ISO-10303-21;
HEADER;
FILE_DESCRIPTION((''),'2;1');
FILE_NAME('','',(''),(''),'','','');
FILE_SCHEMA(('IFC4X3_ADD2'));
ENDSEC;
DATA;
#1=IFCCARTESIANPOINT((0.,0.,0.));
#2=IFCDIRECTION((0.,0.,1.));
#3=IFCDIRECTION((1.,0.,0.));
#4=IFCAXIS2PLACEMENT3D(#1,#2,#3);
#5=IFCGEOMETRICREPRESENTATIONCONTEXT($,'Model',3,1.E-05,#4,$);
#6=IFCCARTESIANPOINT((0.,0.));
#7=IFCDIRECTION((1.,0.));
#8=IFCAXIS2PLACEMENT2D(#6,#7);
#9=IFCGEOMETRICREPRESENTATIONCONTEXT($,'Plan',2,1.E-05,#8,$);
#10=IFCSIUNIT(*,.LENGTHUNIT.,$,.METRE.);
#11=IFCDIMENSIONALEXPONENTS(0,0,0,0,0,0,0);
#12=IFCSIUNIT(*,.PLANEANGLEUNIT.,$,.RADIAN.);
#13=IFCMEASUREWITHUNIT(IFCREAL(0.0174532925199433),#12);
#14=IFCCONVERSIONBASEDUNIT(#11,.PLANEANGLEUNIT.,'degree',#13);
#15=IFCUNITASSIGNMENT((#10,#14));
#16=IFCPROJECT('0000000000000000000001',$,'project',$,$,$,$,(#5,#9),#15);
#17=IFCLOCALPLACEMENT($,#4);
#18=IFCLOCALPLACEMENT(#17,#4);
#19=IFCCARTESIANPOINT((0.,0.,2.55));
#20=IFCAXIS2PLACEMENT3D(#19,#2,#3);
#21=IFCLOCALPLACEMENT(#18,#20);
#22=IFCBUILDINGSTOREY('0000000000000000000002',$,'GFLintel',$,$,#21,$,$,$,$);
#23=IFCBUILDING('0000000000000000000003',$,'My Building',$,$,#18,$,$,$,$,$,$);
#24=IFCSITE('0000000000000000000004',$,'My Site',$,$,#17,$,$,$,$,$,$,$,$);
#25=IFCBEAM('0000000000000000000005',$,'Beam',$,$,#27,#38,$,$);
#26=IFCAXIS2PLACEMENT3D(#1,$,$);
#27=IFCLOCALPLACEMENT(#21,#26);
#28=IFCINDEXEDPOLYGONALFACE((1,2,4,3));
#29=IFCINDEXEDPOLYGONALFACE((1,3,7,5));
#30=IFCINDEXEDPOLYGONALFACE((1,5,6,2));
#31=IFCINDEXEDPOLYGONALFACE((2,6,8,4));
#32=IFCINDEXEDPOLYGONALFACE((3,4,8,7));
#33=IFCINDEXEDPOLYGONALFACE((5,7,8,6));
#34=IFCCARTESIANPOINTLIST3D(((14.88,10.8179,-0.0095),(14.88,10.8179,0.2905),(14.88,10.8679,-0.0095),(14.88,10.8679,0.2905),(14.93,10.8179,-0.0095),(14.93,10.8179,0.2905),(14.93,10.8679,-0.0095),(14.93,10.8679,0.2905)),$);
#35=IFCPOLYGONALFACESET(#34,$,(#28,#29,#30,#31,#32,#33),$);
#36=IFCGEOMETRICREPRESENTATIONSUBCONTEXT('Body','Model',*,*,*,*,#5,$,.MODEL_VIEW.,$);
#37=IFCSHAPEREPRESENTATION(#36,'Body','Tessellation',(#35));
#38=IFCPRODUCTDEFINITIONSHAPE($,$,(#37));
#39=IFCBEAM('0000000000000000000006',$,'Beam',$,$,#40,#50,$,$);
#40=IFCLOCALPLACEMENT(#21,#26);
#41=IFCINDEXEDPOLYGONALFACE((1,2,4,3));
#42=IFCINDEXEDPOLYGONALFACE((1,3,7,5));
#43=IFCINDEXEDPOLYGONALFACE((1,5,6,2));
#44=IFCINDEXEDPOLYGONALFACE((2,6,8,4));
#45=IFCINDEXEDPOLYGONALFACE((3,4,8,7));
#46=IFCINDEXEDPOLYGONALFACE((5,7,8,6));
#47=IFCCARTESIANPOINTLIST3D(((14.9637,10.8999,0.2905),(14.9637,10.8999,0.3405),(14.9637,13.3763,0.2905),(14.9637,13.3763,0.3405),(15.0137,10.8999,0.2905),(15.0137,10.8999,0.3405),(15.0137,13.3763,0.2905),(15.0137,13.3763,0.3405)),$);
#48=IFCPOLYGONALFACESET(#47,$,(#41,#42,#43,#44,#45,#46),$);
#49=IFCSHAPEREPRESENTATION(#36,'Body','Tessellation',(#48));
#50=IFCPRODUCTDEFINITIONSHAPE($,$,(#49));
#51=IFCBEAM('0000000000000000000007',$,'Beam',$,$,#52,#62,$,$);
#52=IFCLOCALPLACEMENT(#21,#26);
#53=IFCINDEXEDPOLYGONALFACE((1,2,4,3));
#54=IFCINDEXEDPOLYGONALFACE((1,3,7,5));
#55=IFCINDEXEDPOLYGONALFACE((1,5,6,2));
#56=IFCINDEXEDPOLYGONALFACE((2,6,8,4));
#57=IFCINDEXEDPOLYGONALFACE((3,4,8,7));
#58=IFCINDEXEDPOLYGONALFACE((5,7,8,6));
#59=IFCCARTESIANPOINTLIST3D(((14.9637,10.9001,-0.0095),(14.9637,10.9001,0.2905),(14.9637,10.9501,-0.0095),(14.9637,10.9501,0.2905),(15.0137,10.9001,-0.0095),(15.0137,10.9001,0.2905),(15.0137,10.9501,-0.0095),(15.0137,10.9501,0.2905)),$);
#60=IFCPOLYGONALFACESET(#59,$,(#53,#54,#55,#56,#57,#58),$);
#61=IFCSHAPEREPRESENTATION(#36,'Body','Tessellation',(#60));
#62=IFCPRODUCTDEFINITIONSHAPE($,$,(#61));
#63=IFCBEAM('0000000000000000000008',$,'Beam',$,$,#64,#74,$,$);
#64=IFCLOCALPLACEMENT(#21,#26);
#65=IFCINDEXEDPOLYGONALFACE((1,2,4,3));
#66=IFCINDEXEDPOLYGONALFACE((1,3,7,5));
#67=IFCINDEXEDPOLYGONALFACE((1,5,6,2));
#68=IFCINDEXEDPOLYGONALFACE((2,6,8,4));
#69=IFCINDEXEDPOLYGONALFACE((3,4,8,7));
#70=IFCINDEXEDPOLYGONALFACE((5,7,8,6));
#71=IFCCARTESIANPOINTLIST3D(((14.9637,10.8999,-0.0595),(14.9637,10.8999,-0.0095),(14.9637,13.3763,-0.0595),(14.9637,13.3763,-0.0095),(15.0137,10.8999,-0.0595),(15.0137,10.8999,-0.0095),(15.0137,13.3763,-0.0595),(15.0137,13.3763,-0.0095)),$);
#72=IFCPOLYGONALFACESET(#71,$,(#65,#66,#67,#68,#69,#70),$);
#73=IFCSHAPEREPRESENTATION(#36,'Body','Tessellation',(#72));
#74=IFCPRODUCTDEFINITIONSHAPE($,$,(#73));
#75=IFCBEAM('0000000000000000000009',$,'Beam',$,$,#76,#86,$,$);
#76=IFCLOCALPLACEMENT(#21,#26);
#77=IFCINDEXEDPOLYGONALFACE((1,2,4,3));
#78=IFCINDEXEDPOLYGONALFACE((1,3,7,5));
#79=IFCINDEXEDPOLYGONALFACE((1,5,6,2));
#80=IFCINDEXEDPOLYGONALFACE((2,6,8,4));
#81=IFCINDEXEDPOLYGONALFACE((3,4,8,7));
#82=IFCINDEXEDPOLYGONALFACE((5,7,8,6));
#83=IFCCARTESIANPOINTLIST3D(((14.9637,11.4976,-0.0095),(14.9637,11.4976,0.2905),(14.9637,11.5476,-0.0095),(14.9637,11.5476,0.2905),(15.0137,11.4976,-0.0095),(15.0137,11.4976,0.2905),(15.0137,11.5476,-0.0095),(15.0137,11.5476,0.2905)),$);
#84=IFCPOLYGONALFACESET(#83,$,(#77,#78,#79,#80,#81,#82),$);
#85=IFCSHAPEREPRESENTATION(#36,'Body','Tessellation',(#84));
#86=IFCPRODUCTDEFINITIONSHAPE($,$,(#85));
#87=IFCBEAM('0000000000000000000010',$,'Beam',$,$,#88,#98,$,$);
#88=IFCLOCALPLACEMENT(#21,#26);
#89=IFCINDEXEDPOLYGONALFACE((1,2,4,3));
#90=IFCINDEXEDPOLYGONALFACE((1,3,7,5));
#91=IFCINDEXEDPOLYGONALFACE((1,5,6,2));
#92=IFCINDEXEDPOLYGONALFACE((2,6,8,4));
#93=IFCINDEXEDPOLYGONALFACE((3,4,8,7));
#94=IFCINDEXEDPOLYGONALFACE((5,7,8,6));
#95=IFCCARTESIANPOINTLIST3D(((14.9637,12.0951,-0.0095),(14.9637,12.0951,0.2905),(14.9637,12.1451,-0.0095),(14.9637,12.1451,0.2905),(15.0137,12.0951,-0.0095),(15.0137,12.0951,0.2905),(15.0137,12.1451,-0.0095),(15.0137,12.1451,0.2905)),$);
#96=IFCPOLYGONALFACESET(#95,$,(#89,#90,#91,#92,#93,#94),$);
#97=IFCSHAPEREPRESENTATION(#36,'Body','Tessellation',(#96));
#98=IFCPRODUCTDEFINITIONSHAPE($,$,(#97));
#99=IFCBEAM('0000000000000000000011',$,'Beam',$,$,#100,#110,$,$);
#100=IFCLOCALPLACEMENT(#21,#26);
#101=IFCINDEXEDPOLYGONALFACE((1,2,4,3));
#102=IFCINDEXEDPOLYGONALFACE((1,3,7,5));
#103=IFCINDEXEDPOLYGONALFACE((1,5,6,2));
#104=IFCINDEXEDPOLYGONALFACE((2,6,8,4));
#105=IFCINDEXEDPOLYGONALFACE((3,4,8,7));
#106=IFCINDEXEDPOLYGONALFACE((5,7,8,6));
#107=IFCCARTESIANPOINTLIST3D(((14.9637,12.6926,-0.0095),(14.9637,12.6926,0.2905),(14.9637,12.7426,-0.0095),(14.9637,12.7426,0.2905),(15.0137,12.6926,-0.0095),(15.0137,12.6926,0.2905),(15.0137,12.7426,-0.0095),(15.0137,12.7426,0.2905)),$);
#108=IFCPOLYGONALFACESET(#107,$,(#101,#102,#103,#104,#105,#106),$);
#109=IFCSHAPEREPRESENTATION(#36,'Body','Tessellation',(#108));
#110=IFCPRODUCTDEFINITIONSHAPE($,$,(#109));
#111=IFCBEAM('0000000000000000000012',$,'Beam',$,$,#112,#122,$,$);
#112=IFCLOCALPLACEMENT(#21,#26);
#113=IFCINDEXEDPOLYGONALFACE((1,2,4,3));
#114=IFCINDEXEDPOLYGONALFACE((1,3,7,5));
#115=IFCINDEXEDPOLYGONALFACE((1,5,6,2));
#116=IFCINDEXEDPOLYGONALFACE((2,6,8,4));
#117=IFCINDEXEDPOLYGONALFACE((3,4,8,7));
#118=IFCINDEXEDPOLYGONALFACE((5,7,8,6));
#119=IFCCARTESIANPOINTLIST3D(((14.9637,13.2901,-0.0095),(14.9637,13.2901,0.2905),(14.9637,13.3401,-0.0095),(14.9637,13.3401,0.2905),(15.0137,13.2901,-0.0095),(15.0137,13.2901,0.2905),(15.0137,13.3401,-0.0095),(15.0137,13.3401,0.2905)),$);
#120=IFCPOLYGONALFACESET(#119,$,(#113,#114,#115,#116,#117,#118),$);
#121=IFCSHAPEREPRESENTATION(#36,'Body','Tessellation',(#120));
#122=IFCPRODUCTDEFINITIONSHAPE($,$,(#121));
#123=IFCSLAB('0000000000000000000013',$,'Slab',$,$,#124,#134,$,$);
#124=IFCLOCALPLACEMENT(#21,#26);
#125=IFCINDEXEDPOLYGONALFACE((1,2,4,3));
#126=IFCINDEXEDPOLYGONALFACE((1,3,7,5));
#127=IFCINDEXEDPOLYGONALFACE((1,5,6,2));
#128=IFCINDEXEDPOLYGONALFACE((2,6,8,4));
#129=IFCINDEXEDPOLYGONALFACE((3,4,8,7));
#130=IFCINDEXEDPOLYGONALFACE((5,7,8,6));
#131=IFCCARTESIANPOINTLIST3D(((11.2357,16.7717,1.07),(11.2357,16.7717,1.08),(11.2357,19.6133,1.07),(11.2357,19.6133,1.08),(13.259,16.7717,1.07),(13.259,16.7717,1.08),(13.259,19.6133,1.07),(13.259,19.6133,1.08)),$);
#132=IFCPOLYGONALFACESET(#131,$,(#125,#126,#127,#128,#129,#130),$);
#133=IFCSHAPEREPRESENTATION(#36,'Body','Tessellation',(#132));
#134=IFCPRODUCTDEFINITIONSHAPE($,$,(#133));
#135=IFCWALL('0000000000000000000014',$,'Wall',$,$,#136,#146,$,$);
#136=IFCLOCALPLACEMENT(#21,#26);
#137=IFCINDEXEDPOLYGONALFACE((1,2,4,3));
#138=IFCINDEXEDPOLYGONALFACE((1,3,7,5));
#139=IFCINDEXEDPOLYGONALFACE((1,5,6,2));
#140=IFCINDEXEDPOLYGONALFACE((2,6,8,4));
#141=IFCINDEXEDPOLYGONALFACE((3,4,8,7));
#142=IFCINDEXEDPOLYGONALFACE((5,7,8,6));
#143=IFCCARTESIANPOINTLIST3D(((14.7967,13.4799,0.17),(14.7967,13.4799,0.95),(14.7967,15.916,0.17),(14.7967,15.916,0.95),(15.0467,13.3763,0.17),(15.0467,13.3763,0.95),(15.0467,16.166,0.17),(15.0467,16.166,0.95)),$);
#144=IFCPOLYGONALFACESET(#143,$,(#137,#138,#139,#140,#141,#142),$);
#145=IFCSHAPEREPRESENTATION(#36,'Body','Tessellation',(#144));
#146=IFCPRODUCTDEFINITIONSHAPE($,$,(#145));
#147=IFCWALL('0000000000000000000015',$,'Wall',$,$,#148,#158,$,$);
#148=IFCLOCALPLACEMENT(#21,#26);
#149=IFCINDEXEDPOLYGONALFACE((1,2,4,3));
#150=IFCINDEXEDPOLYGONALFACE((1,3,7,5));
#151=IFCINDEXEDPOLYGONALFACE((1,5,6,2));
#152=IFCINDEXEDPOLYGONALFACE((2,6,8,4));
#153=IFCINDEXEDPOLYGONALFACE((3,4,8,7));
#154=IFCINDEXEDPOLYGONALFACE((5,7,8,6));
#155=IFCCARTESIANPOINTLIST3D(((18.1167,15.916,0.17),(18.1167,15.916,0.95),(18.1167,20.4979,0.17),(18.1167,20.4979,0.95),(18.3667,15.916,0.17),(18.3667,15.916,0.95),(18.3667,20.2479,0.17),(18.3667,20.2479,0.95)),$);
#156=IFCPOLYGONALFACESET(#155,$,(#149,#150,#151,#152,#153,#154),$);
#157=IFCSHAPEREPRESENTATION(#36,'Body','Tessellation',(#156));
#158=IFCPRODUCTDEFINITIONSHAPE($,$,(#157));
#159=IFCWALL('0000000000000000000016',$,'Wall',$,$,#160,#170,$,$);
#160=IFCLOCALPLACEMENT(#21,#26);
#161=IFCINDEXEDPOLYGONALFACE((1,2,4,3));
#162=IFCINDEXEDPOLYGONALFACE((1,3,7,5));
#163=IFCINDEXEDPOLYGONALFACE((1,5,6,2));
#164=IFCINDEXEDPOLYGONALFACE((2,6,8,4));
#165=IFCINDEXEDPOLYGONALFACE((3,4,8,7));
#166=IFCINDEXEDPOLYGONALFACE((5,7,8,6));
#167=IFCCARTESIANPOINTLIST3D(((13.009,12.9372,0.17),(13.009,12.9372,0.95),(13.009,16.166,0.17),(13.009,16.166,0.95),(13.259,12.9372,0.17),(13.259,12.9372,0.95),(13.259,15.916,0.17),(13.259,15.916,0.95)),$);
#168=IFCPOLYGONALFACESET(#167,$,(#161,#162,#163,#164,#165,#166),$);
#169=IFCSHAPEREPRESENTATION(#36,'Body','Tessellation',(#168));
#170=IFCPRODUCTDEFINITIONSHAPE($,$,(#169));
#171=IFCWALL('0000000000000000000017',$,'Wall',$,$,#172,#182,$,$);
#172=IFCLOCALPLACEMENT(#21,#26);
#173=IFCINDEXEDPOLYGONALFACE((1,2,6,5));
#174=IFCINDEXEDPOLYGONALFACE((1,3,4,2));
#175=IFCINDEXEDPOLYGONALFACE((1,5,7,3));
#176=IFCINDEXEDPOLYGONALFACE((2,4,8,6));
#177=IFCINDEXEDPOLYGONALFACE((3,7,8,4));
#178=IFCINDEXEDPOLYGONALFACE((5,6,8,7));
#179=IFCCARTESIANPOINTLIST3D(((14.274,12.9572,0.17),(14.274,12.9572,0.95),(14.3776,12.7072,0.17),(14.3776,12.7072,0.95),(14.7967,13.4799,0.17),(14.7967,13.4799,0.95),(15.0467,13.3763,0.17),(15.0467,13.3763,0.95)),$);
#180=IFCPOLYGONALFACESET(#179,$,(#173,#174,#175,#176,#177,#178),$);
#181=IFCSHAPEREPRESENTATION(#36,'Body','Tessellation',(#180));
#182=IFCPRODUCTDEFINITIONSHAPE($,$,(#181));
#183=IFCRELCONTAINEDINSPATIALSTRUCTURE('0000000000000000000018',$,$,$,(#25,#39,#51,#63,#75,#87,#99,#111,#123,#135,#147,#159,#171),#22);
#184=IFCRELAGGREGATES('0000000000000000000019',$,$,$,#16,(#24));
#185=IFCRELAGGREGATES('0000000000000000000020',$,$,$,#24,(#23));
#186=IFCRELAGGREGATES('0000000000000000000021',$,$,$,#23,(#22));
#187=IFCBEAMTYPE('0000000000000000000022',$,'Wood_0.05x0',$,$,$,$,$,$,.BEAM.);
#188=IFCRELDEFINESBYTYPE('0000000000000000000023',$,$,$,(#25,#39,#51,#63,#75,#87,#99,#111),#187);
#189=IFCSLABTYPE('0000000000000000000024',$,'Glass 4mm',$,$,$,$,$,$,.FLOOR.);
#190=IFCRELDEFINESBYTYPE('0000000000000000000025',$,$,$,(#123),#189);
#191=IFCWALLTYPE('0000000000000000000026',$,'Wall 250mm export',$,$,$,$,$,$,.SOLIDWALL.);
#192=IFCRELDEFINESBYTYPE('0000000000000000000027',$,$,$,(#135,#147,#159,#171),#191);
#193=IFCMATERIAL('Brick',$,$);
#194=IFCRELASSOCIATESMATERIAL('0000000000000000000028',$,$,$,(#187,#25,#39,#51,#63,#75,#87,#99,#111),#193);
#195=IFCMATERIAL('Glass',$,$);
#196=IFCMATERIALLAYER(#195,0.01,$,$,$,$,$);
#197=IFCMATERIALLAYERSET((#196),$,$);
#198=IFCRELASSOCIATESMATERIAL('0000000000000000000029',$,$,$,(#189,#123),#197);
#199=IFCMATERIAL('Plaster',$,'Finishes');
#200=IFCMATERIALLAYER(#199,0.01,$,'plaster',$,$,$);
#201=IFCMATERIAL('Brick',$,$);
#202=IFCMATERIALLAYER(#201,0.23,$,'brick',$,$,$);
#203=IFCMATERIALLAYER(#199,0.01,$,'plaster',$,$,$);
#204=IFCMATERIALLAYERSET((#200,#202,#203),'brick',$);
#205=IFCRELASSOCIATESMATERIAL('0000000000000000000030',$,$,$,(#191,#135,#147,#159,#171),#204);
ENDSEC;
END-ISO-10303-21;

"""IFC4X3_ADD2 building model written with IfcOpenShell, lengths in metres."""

from ifc_helpers import new_model, entity, si_unit, converted_unit, frame, origin_with_axes, origin_2d_with_axis, place, context, subcontext, project, spatial, line, indexed_curve, rectangle, outline, extrude, material, layer, layer_set, layer_usage, material_profile, profile_set, profile_usage, type_object, element, save


model = new_model("IFC4X3_ADD2")

# Units and contexts
model_context = context("Model", 3, precision=1e-05, world=origin_with_axes())
plan_context = context("Plan", 2, precision=1e-05, world=origin_2d_with_axis())
body_context = subcontext(model_context, "Body", "Model", "MODEL_VIEW")
ifc_project = project(units=[si_unit("LENGTHUNIT", "METRE"), converted_unit("PLANEANGLEUNIT", "degree", entity("IfcReal", 0.0174532925199433), si_unit("PLANEANGLEUNIT", "RADIAN"), dimensions=[0, 0, 0, 0, 0, 0, 0])], contexts=[model_context, plan_context])

# Site, building, storey
site_placement = place(None, origin_with_axes())
site = spatial("IfcSite", under=ifc_project, at=site_placement, Name="My Site")
building_placement = place(site_placement, origin_with_axes())
building = spatial("IfcBuilding", under=site, at=building_placement, Name="My Building")
storey_placement = place(building_placement, frame((0.0, 0.0, 2.55), z_axis=(0.0, 0.0, 1.0), x_axis=(1.0, 0.0, 0.0)))
storey = spatial("IfcBuildingStorey", under=building, at=storey_placement, Name="GFLintel")

# Beams
ifc_material_1 = material(Name="Brick")
ifc_material_profile_1 = material_profile(ifc_material_1, rectangle(XDim=0.05, YDim=0.05))
ifc_profile_set_1 = profile_set([ifc_material_profile_1])
beam_type_1 = type_object("IfcBeamType", Name="Wood_0.05x0", PredefinedType="BEAM", material=ifc_profile_set_1)
ifc_profile_usage_1 = profile_usage(ifc_profile_set_1, cardinal=5)
beam_1_placement = place(storey_placement, frame((14.905, 10.8429, -0.0095), z_axis=(-0.000001, 0.0, 1.0), x_axis=(0.0, 1.0, 0.0)))
element("IfcBeam", 1, at=beam_1_placement, inside=storey, type_object=beam_type_1, material=ifc_profile_usage_1, Name="Beam", context=body_context, shape_type="SweptSolid", body=[
    extrude(rectangle(XDim=0.05, YDim=0.05), origin_with_axes(), (0.0, 0.0, 1.0), 0.3),
])
ifc_profile_usage_2 = profile_usage(ifc_profile_set_1, cardinal=5)
beam_2_placement = place(storey_placement, frame((14.9887, 10.8999, 0.3155), z_axis=(0.0, 1.0, 0.000001), x_axis=(-1.0, 0.0, 0.0)))
element("IfcBeam", 2, at=beam_2_placement, inside=storey, type_object=beam_type_1, material=ifc_profile_usage_2, Name="Beam", context=body_context, shape_type="SweptSolid", body=[
    extrude(rectangle(XDim=0.05, YDim=0.05), origin_with_axes(), (0.0, 0.0, 1.0), 2.4764),
])
ifc_profile_usage_3 = profile_usage(ifc_profile_set_1, cardinal=5)
beam_3_placement = place(storey_placement, frame((14.9887, 10.9251, -0.0095), z_axis=(0.0, -0.000001, 1.0), x_axis=(-1.0, 0.0, 0.0)))
element("IfcBeam", 3, at=beam_3_placement, inside=storey, type_object=beam_type_1, material=ifc_profile_usage_3, Name="Beam", context=body_context, shape_type="SweptSolid", body=[
    extrude(rectangle(XDim=0.05, YDim=0.05), origin_with_axes(), (0.0, 0.0, 1.0), 0.3),
])
ifc_profile_usage_4 = profile_usage(ifc_profile_set_1, cardinal=5)
beam_4_placement = place(storey_placement, frame((14.9887, 10.8999, -0.0345), z_axis=(0.0, 1.0, 0.000001), x_axis=(-1.0, 0.0, 0.0)))
element("IfcBeam", 4, at=beam_4_placement, inside=storey, type_object=beam_type_1, material=ifc_profile_usage_4, Name="Beam", context=body_context, shape_type="SweptSolid", body=[
    extrude(rectangle(XDim=0.05, YDim=0.05), origin_with_axes(), (0.0, 0.0, 1.0), 2.4764),
])
ifc_profile_usage_5 = profile_usage(ifc_profile_set_1, cardinal=5)
beam_5_placement = place(storey_placement, frame((14.9887, 11.5226, -0.0095), z_axis=(0.0, -0.000001, 1.0), x_axis=(-1.0, 0.0, 0.0)))
element("IfcBeam", 5, at=beam_5_placement, inside=storey, type_object=beam_type_1, material=ifc_profile_usage_5, Name="Beam", context=body_context, shape_type="SweptSolid", body=[
    extrude(rectangle(XDim=0.05, YDim=0.05), origin_with_axes(), (0.0, 0.0, 1.0), 0.3),
])
ifc_profile_usage_6 = profile_usage(ifc_profile_set_1, cardinal=5)
beam_6_placement = place(storey_placement, frame((14.9887, 12.1201, -0.0095), z_axis=(0.0, -0.000001, 1.0), x_axis=(-1.0, 0.0, 0.0)))
element("IfcBeam", 6, at=beam_6_placement, inside=storey, type_object=beam_type_1, material=ifc_profile_usage_6, Name="Beam", context=body_context, shape_type="SweptSolid", body=[
    extrude(rectangle(XDim=0.05, YDim=0.05), origin_with_axes(), (0.0, 0.0, 1.0), 0.3),
])
ifc_profile_usage_7 = profile_usage(ifc_profile_set_1, cardinal=5)
beam_7_placement = place(storey_placement, frame((14.9887, 12.7176, -0.0095), z_axis=(0.0, -0.000001, 1.0), x_axis=(-1.0, 0.0, 0.0)))
element("IfcBeam", 7, at=beam_7_placement, inside=storey, type_object=beam_type_1, material=ifc_profile_usage_7, Name="Beam", context=body_context, shape_type="SweptSolid", body=[
    extrude(rectangle(XDim=0.05, YDim=0.05), origin_with_axes(), (0.0, 0.0, 1.0), 0.3),
])
ifc_profile_usage_8 = profile_usage(ifc_profile_set_1, cardinal=5)
beam_8_placement = place(storey_placement, frame((14.9887, 13.3151, -0.0095), z_axis=(0.0, -0.000001, 1.0), x_axis=(-1.0, 0.0, 0.0)))
element("IfcBeam", 8, at=beam_8_placement, inside=storey, type_object=beam_type_1, material=ifc_profile_usage_8, Name="Beam", context=body_context, shape_type="SweptSolid", body=[
    extrude(rectangle(XDim=0.05, YDim=0.05), origin_with_axes(), (0.0, 0.0, 1.0), 0.3),
])

# Slab
ifc_material_2 = material(Name="Glass")
ifc_layer_1 = layer(ifc_material_2, 0.01)
ifc_layer_set_1 = layer_set([ifc_layer_1])
ifc_layer_usage_1 = layer_usage(ifc_layer_set_1, "AXIS3", "POSITIVE", 0.0)
slab_type = type_object("IfcSlabType", Name="Glass 4mm", PredefinedType="FLOOR", material=ifc_layer_set_1)
slab_placement = place(storey_placement, frame((13.259, 16.7717, 1.07), z_axis=(0.0, 0.0, 1.0), x_axis=(0.0, 1.0, 0.0)))
element("IfcSlab", 9, at=slab_placement, inside=storey, type_object=slab_type, material=ifc_layer_usage_1, Name="Slab", context=body_context, shape_type="SweptSolid", body=[
    extrude(outline(indexed_curve([(0.0, 2.0233), (2.8416, 2.0233), (2.8416, 0.0), (0.0, 0.0), (0.0, 2.0233)])), None, (0.0, 0.0, 1.0), 0.01),
])

# Walls
ifc_material_3 = material(Name="Plaster", Category="Finishes")
ifc_layer_2 = layer(ifc_material_3, 0.01, Name="plaster")
ifc_material_4 = material(Name="Brick")
ifc_layer_3 = layer(ifc_material_4, 0.23, Name="brick")
ifc_layer_4 = layer(ifc_material_3, 0.01, Name="plaster")
ifc_layer_set_2 = layer_set([ifc_layer_2, ifc_layer_3, ifc_layer_4], Name="brick")
wall_type_1 = type_object("IfcWallType", Name="Wall 250mm export", PredefinedType="SOLIDWALL", material=ifc_layer_set_2)
ifc_layer_usage_2 = layer_usage(ifc_layer_set_2, "AXIS2", "POSITIVE", 0.0)
wall_1_placement = place(storey_placement, frame((15.0467, 13.3763, 0.17), z_axis=(0.0, 0.0, 1.0), x_axis=(0.0, 1.0, 0.0)))
element("IfcWall", 10, at=wall_1_placement, inside=storey, type_object=wall_type_1, material=ifc_layer_usage_2, Name="Wall", context=body_context, shape_type="SweptSolid", body=[
    extrude(outline(indexed_curve([(0.0, 0.0), (0.1036, 0.25), (2.5397, 0.25), (2.7897, 0.0)], segments=[line(1, 2, 3, 4, 1)])), origin_with_axes(), (0.0, 0.0, 1.0), 0.78),
])
ifc_layer_usage_3 = layer_usage(ifc_layer_set_2, "AXIS2", "NEGATIVE", 0.0)
wall_2_placement = place(storey_placement, frame((18.1167, 15.916, 0.17), z_axis=(0.0, 0.0, 1.0), x_axis=(0.0, 1.0, 0.0)))
element("IfcWall", 11, at=wall_2_placement, inside=storey, type_object=wall_type_1, material=ifc_layer_usage_3, Name="Wall", context=body_context, shape_type="SweptSolid", body=[
    extrude(outline(indexed_curve([(0.0, -0.25), (0.0, 0.0), (4.5819, 0.0), (4.3319, -0.25)], segments=[line(1, 2, 3, 4, 1)])), origin_with_axes(), (0.0, 0.0, 1.0), 0.78),
])
ifc_layer_usage_4 = layer_usage(ifc_layer_set_2, "AXIS2", "POSITIVE", 0.0)
wall_3_placement = place(storey_placement, frame((13.259, 12.9372, 0.17), z_axis=(0.0, 0.0, 1.0), x_axis=(0.0, 1.0, 0.0)))
element("IfcWall", 12, at=wall_3_placement, inside=storey, type_object=wall_type_1, material=ifc_layer_usage_4, Name="Wall", context=body_context, shape_type="SweptSolid", body=[
    extrude(outline(indexed_curve([(0.0, 0.0), (0.0, 0.25), (3.2288, 0.25), (2.9788, 0.0)], segments=[line(1, 2, 3, 4, 1)])), origin_with_axes(), (0.0, 0.0, 1.0), 0.78),
])
ifc_layer_usage_5 = layer_usage(ifc_layer_set_2, "AXIS2", "POSITIVE", 0.0)
wall_4_placement = place(storey_placement, frame((14.3776, 12.7072, 0.17), z_axis=(0.0, 0.0, 1.0), x_axis=(0.707107, 0.707107, 0.0)))
element("IfcWall", 13, at=wall_4_placement, inside=storey, type_object=wall_type_1, material=ifc_layer_usage_5, Name="Wall", context=body_context, shape_type="SweptSolid", body=[
    extrude(outline(indexed_curve([(0.0, 0.0), (0.1036, 0.25), (0.8427, 0.25), (0.9463, 0.0)], segments=[line(1, 2, 3, 4, 1)])), origin_with_axes(), (0.0, 0.0, 1.0), 0.78),
])

save(model, "model.ifc")
